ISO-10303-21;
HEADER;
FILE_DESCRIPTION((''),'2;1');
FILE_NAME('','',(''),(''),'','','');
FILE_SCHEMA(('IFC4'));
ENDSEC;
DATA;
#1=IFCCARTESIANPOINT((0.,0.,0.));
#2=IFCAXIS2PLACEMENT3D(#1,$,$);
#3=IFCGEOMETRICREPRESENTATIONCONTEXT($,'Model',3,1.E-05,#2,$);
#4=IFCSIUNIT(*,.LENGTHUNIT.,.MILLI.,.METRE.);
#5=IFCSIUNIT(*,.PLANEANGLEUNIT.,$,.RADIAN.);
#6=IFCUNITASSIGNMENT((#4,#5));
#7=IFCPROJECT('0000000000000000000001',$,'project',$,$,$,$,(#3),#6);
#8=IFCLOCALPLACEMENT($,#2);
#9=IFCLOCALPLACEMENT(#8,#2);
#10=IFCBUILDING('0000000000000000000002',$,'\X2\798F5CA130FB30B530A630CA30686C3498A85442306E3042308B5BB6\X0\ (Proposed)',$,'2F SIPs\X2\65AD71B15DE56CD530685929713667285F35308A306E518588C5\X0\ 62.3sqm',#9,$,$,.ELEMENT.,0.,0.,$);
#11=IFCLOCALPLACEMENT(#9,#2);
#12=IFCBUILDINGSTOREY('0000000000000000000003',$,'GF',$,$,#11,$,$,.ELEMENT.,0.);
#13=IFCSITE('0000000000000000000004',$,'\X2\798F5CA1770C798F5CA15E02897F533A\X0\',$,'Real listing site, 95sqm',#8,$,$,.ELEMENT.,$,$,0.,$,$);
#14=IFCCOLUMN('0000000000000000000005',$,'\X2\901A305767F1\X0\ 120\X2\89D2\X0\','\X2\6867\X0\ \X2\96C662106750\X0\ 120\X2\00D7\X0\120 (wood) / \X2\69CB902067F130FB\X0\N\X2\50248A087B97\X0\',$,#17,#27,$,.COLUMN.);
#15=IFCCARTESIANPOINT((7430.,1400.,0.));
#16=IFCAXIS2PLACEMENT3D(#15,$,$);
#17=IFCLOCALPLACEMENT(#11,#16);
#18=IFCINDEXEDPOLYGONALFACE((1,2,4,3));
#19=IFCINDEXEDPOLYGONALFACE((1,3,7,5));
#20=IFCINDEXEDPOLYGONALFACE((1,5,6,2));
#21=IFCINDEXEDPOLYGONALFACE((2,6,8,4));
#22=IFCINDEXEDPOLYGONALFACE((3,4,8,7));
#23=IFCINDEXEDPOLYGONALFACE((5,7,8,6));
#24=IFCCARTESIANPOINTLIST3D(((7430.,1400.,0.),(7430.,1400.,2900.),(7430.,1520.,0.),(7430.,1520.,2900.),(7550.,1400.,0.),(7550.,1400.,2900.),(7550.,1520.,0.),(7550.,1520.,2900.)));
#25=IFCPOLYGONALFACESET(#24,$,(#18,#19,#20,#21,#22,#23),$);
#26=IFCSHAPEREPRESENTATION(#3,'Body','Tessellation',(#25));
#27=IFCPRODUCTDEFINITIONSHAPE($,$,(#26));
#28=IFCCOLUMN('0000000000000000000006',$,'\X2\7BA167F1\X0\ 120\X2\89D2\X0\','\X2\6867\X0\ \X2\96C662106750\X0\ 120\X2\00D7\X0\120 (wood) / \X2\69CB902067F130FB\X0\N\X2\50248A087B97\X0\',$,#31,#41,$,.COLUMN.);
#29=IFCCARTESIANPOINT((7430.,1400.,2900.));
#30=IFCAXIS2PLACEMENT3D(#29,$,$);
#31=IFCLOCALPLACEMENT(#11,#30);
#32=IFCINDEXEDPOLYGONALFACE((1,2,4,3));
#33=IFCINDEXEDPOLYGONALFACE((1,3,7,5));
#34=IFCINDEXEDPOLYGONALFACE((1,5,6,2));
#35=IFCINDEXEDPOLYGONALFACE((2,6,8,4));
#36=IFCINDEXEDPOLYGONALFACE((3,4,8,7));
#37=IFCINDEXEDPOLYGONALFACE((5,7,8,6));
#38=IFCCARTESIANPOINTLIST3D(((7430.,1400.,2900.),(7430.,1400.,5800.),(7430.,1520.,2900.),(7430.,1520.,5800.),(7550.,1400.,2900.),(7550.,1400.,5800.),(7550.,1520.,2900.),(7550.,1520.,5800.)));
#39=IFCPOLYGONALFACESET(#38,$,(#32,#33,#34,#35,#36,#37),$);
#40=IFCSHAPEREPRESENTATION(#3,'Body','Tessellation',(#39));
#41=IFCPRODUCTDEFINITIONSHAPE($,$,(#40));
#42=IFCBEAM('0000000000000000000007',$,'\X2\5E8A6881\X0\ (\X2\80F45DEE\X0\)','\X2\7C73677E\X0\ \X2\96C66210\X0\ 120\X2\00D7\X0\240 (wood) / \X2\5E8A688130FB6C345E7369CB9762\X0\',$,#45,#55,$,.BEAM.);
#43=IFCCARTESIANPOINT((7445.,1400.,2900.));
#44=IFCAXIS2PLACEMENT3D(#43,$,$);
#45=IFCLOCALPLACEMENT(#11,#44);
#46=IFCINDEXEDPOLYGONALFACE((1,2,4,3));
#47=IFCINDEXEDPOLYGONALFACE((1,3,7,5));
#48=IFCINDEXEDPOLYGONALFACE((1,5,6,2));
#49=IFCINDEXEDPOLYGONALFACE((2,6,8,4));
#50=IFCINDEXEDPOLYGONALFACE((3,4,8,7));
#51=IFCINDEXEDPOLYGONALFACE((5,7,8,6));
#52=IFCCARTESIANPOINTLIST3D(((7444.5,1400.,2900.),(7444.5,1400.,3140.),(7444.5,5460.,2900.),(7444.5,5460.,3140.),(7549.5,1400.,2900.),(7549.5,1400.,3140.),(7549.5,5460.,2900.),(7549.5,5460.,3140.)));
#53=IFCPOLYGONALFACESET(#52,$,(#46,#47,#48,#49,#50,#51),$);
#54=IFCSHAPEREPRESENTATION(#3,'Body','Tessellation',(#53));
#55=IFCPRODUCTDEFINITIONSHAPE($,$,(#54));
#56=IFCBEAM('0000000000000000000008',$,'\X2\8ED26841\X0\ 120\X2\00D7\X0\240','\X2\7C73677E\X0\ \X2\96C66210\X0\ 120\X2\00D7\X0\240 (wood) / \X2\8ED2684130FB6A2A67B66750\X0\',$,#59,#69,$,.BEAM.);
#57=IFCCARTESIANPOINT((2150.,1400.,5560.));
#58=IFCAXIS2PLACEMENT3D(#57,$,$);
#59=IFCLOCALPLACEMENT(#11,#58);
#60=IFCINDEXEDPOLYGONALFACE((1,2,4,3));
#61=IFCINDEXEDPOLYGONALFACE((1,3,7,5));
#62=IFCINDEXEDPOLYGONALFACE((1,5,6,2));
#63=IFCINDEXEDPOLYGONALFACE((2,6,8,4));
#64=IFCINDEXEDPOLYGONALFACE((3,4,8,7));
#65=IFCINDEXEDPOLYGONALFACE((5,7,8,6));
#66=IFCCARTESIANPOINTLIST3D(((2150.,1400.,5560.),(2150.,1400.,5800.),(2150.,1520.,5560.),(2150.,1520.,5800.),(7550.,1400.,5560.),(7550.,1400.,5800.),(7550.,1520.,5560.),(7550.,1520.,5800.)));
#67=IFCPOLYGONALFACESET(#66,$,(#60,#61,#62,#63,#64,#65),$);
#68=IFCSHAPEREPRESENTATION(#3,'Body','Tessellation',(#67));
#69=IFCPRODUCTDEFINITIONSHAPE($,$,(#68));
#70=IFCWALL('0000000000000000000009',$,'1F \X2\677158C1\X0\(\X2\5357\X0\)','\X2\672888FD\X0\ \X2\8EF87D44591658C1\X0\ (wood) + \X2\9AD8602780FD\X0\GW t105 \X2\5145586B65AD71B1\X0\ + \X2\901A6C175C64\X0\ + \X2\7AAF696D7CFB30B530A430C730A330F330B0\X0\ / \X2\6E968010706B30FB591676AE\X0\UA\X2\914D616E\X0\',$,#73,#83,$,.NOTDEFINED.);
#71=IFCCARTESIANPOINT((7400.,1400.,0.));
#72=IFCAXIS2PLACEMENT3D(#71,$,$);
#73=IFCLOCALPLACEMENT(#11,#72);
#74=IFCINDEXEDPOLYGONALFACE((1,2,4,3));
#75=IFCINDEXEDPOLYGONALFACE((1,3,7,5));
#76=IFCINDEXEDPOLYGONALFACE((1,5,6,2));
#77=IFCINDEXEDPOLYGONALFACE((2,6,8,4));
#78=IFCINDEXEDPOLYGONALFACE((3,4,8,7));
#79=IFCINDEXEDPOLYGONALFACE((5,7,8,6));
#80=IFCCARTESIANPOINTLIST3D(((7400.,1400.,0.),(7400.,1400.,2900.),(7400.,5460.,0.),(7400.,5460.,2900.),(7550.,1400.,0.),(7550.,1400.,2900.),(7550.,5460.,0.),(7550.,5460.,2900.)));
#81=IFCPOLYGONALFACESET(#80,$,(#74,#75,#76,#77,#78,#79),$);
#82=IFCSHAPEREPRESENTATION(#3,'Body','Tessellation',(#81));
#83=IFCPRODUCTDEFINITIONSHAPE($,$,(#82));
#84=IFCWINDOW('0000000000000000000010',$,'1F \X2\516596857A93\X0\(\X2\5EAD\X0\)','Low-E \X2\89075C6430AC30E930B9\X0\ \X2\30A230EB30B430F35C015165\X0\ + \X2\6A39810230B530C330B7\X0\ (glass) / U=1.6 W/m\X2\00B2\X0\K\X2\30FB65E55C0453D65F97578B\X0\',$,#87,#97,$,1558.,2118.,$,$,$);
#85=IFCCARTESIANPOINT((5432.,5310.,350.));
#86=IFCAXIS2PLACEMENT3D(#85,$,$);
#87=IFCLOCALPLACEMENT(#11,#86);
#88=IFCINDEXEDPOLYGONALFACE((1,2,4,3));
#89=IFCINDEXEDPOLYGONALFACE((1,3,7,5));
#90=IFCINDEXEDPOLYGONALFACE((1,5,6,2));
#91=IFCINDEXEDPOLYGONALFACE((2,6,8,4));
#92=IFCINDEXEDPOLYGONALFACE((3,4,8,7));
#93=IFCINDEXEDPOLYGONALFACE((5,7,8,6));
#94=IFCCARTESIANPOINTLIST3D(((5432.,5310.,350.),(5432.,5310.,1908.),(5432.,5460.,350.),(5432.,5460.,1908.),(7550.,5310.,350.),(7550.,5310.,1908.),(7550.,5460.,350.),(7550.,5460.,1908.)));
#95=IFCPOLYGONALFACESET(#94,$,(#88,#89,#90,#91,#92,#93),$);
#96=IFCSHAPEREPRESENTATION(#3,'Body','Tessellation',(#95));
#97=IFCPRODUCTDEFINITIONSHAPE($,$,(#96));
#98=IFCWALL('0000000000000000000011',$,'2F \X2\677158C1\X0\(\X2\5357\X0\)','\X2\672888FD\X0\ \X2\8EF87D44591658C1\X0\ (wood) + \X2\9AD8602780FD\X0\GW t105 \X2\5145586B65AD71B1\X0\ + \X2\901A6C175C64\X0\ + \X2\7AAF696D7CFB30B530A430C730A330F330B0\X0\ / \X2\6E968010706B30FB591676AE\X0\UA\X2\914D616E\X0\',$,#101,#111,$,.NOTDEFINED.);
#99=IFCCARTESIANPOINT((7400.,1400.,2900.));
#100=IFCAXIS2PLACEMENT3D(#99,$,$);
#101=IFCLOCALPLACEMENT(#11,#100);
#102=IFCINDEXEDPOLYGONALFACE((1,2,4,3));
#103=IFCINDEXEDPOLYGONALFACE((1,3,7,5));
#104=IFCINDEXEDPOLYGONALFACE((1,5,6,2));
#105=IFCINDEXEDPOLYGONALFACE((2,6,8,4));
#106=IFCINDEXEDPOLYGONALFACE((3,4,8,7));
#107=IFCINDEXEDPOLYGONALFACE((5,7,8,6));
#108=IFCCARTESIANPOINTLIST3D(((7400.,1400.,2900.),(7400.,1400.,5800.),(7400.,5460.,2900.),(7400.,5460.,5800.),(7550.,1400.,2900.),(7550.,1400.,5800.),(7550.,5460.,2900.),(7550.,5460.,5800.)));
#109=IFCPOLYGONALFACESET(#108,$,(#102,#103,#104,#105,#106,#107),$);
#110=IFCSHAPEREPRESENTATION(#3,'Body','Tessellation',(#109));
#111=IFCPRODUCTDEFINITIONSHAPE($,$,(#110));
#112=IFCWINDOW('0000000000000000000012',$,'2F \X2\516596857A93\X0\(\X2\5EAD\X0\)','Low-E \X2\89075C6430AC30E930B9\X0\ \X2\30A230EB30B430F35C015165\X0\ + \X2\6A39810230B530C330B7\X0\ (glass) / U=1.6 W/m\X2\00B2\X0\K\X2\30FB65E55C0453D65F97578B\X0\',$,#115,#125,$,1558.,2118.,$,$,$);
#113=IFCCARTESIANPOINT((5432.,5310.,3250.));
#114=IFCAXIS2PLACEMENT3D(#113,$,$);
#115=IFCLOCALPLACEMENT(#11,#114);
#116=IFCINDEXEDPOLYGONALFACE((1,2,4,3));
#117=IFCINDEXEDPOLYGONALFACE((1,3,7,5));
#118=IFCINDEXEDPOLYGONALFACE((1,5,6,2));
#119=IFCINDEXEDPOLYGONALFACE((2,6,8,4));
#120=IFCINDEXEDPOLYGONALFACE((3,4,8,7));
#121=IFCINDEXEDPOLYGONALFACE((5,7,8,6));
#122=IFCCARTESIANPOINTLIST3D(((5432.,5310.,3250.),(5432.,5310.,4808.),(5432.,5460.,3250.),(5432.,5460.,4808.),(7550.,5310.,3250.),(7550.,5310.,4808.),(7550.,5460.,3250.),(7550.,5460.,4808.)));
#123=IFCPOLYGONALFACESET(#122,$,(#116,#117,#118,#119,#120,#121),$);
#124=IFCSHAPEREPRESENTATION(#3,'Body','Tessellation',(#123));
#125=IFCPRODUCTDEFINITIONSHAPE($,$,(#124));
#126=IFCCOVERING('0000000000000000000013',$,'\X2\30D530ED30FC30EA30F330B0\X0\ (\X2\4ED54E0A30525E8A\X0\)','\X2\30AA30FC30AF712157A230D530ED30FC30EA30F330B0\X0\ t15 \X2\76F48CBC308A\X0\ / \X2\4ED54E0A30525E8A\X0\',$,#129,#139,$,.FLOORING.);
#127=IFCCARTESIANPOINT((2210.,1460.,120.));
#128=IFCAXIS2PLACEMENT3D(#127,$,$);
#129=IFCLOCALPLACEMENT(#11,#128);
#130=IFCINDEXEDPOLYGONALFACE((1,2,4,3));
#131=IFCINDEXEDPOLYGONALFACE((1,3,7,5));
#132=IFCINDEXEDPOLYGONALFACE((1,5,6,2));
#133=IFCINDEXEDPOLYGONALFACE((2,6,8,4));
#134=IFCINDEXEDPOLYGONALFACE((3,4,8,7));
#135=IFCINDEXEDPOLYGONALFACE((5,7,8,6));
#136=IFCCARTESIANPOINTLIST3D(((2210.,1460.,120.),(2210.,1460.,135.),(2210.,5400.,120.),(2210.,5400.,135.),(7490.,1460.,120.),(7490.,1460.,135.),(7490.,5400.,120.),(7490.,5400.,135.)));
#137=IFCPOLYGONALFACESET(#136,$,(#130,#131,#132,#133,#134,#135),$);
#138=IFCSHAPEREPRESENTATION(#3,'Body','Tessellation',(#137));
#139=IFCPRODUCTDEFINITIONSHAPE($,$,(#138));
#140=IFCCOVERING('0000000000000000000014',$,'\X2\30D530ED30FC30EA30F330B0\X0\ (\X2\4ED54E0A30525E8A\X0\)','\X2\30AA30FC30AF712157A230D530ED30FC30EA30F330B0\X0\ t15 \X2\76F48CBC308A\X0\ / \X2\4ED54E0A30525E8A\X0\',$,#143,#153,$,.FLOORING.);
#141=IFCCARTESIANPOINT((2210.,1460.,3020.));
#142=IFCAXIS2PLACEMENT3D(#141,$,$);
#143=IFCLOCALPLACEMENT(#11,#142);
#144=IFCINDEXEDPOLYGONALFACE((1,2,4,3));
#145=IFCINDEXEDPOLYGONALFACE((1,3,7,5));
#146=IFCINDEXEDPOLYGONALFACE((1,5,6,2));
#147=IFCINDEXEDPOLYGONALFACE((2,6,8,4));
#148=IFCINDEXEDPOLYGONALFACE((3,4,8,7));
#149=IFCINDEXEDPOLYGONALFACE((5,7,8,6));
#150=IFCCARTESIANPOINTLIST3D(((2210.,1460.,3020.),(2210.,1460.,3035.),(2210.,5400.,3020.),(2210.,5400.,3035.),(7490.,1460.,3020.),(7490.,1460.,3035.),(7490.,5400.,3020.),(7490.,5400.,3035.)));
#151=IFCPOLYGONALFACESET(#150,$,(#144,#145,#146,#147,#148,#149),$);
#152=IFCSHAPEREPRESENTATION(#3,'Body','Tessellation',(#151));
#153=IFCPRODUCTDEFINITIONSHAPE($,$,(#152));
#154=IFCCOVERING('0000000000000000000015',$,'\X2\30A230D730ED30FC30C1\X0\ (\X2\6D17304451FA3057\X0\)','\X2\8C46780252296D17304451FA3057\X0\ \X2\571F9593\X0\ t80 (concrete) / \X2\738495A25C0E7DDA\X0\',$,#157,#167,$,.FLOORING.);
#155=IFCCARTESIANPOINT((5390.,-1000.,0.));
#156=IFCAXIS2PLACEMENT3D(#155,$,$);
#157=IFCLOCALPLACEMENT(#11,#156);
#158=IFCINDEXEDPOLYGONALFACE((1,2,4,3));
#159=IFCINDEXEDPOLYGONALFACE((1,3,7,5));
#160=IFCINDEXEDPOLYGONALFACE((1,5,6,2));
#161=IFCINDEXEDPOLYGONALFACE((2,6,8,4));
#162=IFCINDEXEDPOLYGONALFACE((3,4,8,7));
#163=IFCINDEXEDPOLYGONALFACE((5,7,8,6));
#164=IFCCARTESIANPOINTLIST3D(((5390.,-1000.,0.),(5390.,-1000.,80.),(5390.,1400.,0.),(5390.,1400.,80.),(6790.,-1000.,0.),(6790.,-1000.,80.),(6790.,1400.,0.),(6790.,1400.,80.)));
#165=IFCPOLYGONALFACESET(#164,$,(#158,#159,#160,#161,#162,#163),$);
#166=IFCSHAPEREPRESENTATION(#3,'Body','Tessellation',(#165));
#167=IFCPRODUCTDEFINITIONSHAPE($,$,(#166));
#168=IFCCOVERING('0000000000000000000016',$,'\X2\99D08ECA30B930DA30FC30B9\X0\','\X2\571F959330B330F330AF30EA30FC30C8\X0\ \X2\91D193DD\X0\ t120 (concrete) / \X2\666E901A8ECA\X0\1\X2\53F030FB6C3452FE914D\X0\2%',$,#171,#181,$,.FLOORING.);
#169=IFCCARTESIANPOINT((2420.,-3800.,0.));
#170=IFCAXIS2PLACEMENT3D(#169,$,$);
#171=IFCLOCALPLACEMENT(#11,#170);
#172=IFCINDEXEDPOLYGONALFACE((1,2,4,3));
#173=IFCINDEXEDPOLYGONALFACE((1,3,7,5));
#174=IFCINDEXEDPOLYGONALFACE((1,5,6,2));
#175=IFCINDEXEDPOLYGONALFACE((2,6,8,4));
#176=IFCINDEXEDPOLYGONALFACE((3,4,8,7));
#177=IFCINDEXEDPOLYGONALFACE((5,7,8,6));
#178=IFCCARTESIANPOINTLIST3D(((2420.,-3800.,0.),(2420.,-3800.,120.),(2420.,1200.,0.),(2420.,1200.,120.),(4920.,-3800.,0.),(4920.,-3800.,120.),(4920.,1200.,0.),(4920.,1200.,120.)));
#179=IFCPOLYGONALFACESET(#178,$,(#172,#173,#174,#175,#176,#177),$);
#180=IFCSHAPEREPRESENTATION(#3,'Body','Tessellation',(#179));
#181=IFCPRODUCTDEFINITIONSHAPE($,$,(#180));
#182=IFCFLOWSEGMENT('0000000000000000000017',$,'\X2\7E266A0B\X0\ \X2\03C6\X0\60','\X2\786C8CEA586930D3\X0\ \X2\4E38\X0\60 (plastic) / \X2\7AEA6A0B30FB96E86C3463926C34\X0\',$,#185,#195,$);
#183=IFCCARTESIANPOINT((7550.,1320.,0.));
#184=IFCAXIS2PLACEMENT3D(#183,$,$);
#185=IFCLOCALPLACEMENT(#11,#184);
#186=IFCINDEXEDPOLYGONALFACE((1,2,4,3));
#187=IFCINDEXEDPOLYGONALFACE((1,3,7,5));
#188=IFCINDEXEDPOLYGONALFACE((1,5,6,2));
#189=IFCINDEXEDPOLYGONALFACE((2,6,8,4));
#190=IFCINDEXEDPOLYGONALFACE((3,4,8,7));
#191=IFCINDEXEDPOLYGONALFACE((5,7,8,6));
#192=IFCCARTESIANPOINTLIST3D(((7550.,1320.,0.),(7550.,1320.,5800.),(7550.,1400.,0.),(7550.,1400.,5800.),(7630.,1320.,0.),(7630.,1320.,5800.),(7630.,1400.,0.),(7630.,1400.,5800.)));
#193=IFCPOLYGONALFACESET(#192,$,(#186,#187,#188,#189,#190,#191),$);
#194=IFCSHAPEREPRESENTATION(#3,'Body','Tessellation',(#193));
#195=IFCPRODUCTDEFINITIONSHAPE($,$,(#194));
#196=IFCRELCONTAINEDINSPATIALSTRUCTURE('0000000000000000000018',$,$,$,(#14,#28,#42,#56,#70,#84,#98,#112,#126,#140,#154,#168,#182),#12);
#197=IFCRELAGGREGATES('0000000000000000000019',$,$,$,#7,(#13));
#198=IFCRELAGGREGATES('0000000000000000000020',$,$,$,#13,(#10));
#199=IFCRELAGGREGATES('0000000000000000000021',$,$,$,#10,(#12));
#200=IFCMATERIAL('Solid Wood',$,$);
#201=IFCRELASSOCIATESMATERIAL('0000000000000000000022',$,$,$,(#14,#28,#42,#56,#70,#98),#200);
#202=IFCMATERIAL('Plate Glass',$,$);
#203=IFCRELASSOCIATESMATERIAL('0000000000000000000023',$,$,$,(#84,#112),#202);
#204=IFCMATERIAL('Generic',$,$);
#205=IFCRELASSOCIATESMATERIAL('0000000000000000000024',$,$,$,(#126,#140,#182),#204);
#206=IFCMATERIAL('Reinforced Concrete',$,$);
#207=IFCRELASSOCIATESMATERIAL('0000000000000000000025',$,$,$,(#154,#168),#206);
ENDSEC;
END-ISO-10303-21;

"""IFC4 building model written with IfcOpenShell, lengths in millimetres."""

from ifc_helpers import new_model, si_unit, frame, frame_2d, origin, place, context, project, spatial, rectangle, extrude, material, element, fill, save


model = new_model("IFC4")

# Units and contexts
model_context = context("Model", 3, precision=1e-05, world=origin())
ifc_project = project(units=[si_unit("LENGTHUNIT", "METRE", prefix="MILLI"), si_unit("PLANEANGLEUNIT", "RADIAN")], contexts=[model_context])

# Site, building, storey
site_placement = place(None, origin())
site = spatial("IfcSite", under=ifc_project, at=site_placement, Name="福岡県福岡市西区", ObjectType="Real listing site, 95sqm", CompositionType="ELEMENT", RefElevation=0.0)
building_placement = place(site_placement, origin())
building = spatial("IfcBuilding", under=site, at=building_placement, Name="福岡・サウナと水風呂のある家 (Proposed)", ObjectType="2F SIPs断熱工法と天然木張りの内装 62.3sqm", CompositionType="ELEMENT", ElevationOfRefHeight=0.0, ElevationOfTerrain=0.0)
storey_placement = place(building_placement, origin())
storey = spatial("IfcBuildingStorey", under=building, at=storey_placement, Name="GF", CompositionType="ELEMENT", Elevation=0.0)

# Columns
ifc_material_1 = material(Name="Solid Wood")
column_1_placement = place(storey_placement, frame((7430.0, 1400.0, 0.0)))
element("IfcColumn", 1, at=column_1_placement, inside=storey, material=ifc_material_1, Name="通し柱 120角", Description="桧 集成材 120×120 (wood) / 構造柱・N値計算", PredefinedType="COLUMN", context=model_context, shape_type="SweptSolid", body=[
    extrude(rectangle(XDim=120.0, YDim=120.0, at=frame_2d((60.0, 60.0))), frame((7430.0, 1400.0, 0.0)), (0.0, 0.0, 1.0), 2900.0),
])
column_2_placement = place(storey_placement, frame((7430.0, 1400.0, 2900.0)))
element("IfcColumn", 2, at=column_2_placement, inside=storey, material=ifc_material_1, Name="管柱 120角", Description="桧 集成材 120×120 (wood) / 構造柱・N値計算", PredefinedType="COLUMN", context=model_context, shape_type="SweptSolid", body=[
    extrude(rectangle(XDim=120.0, YDim=120.0, at=frame_2d((60.0, 60.0))), frame((7430.0, 1400.0, 2900.0)), (0.0, 0.0, 1.0), 2900.0),
])

# Beams
beam_1_placement = place(storey_placement, frame((7445.0, 1400.0, 2900.0)))
element("IfcBeam", 3, at=beam_1_placement, inside=storey, material=ifc_material_1, Name="床梁 (胴差)", Description="米松 集成 120×240 (wood) / 床梁・水平構面", PredefinedType="BEAM", context=model_context, shape_type="SweptSolid", body=[
    extrude(rectangle(XDim=105.0, YDim=4060.0, at=frame_2d((52.0, 2030.0))), frame((7445.0, 1400.0, 2900.0)), (0.0, 0.0, 1.0), 240.0),
])
beam_2_placement = place(storey_placement, frame((2150.0, 1400.0, 5560.0)))
element("IfcBeam", 4, at=beam_2_placement, inside=storey, material=ifc_material_1, Name="軒桁 120×240", Description="米松 集成 120×240 (wood) / 軒桁・横架材", PredefinedType="BEAM", context=model_context, shape_type="SweptSolid", body=[
    extrude(rectangle(XDim=5400.0, YDim=120.0, at=frame_2d((2700.0, 60.0))), frame((2150.0, 1400.0, 5560.0)), (0.0, 0.0, 1.0), 240.0),
])

# Wall, opening, window
wall_1_placement = place(storey_placement, frame((7400.0, 1400.0, 0.0)))
wall_1 = element("IfcWall", 5, at=wall_1_placement, inside=storey, material=ifc_material_1, Name="1F 東壁(南)", Description="木製 軸組外壁 (wood) + 高性能GW t105 充填断熱 + 通気層 + 窯業系サイディング / 準耐火・外皮UA配慮", PredefinedType="NOTDEFINED", context=model_context, shape_type="SweptSolid", body=[
    extrude(rectangle(XDim=150.0, YDim=4060.0, at=frame_2d((75.0, 2030.0))), frame((7400.0, 1400.0, 0.0)), (0.0, 0.0, 1.0), 2900.0),
])
opening_1_placement = place(storey_placement, frame((5432.0, 5310.0, 350.0)))
opening_1 = element("IfcOpeningElement", 6, at=opening_1_placement, cuts=wall_1, PredefinedType="NOTDEFINED", context=model_context, shape_type="SweptSolid", body=[
    extrude(rectangle(XDim=2118.0, YDim=150.0, at=frame_2d((1059.0, 75.0))), frame((5432.0, 5310.0, 350.0)), (0.0, 0.0, 1.0), 1558.0),
])
ifc_material_2 = material(Name="Plate Glass")
window_1_placement = place(storey_placement, frame((5432.0, 5310.0, 350.0)))
window_1 = element("IfcWindow", 7, at=window_1_placement, inside=storey, material=ifc_material_2, Name="1F 入隅窓(庭)", Description="Low-E 複層ガラス アルゴン封入 + 樹脂サッシ (glass) / U=1.6 W/m²K・日射取得型", OverallHeight=1558.0, OverallWidth=2118.0, context=model_context, shape_type="SweptSolid", body=[
    extrude(rectangle(XDim=2118.0, YDim=150.0, at=frame_2d((1059.0, 75.0))), frame((5432.0, 5310.0, 350.0)), (0.0, 0.0, 1.0), 1558.0),
])
fill(opening_1, window_1)

# Wall, opening, window
wall_2_placement = place(storey_placement, frame((7400.0, 1400.0, 2900.0)))
wall_2 = element("IfcWall", 8, at=wall_2_placement, inside=storey, material=ifc_material_1, Name="2F 東壁(南)", Description="木製 軸組外壁 (wood) + 高性能GW t105 充填断熱 + 通気層 + 窯業系サイディング / 準耐火・外皮UA配慮", PredefinedType="NOTDEFINED", context=model_context, shape_type="SweptSolid", body=[
    extrude(rectangle(XDim=150.0, YDim=4060.0, at=frame_2d((75.0, 2030.0))), frame((7400.0, 1400.0, 2900.0)), (0.0, 0.0, 1.0), 2900.0),
])
opening_2_placement = place(storey_placement, frame((5432.0, 5310.0, 3250.0)))
opening_2 = element("IfcOpeningElement", 9, at=opening_2_placement, cuts=wall_2, PredefinedType="NOTDEFINED", context=model_context, shape_type="SweptSolid", body=[
    extrude(rectangle(XDim=2118.0, YDim=150.0, at=frame_2d((1059.0, 75.0))), frame((5432.0, 5310.0, 3250.0)), (0.0, 0.0, 1.0), 1558.0),
])
window_2_placement = place(storey_placement, frame((5432.0, 5310.0, 3250.0)))
window_2 = element("IfcWindow", 10, at=window_2_placement, inside=storey, material=ifc_material_2, Name="2F 入隅窓(庭)", Description="Low-E 複層ガラス アルゴン封入 + 樹脂サッシ (glass) / U=1.6 W/m²K・日射取得型", OverallHeight=1558.0, OverallWidth=2118.0, context=model_context, shape_type="SweptSolid", body=[
    extrude(rectangle(XDim=2118.0, YDim=150.0, at=frame_2d((1059.0, 75.0))), frame((5432.0, 5310.0, 3250.0)), (0.0, 0.0, 1.0), 1558.0),
])
fill(opening_2, window_2)

# Coverings
ifc_material_3 = material(Name="Generic")
covering_1_placement = place(storey_placement, frame((2210.0, 1460.0, 120.0)))
element("IfcCovering", 11, at=covering_1_placement, inside=storey, material=ifc_material_3, Name="フローリング (仕上げ床)", Description="オーク無垢フローリング t15 直貼り / 仕上げ床", PredefinedType="FLOORING", context=model_context, shape_type="SweptSolid", body=[
    extrude(rectangle(XDim=5280.0, YDim=3940.0, at=frame_2d((2640.0, 1970.0))), frame((2210.0, 1460.0, 120.0)), (0.0, 0.0, 1.0), 15.0),
])
covering_2_placement = place(storey_placement, frame((2210.0, 1460.0, 3020.0)))
element("IfcCovering", 12, at=covering_2_placement, inside=storey, material=ifc_material_3, Name="フローリング (仕上げ床)", Description="オーク無垢フローリング t15 直貼り / 仕上げ床", PredefinedType="FLOORING", context=model_context, shape_type="SweptSolid", body=[
    extrude(rectangle(XDim=5280.0, YDim=3940.0, at=frame_2d((2640.0, 1970.0))), frame((2210.0, 1460.0, 3020.0)), (0.0, 0.0, 1.0), 15.0),
])
ifc_material_4 = material(Name="Reinforced Concrete")
covering_3_placement = place(storey_placement, frame((5390.0, -1000.0, 0.0)))
element("IfcCovering", 13, at=covering_3_placement, inside=storey, material=ifc_material_4, Name="アプローチ (洗い出し)", Description="豆砂利洗い出し 土間 t80 (concrete) / 玄関導線", PredefinedType="FLOORING", context=model_context, shape_type="SweptSolid", body=[
    extrude(rectangle(XDim=1400.0, YDim=2400.0, at=frame_2d((700.0, 1200.0))), frame((5390.0, -1000.0, 0.0)), (0.0, 0.0, 1.0), 80.0),
])
covering_4_placement = place(storey_placement, frame((2420.0, -3800.0, 0.0)))
element("IfcCovering", 14, at=covering_4_placement, inside=storey, material=ifc_material_4, Name="駐車スペース", Description="土間コンクリート 金鏝 t120 (concrete) / 普通車1台・水勾配2%", PredefinedType="FLOORING", context=model_context, shape_type="SweptSolid", body=[
    extrude(rectangle(XDim=2500.0, YDim=5000.0, at=frame_2d((1250.0, 2500.0))), frame((2420.0, -3800.0, 0.0)), (0.0, 0.0, 1.0), 120.0),
])

# Flow segment
flow_segment_placement = place(storey_placement, frame((7550.0, 1320.0, 0.0)))
element("IfcFlowSegment", 15, at=flow_segment_placement, inside=storey, material=ifc_material_3, Name="縦樋 φ60", Description="硬質塩ビ 丸60 (plastic) / 竪樋・雨水排水", context=model_context, shape_type="SweptSolid", body=[
    extrude(rectangle(XDim=80.0, YDim=80.0, at=frame_2d((40.0, 40.0))), frame((7550.0, 1320.0, 0.0)), (0.0, 0.0, 1.0), 5800.0),
])

save(model, "model.ifc")
